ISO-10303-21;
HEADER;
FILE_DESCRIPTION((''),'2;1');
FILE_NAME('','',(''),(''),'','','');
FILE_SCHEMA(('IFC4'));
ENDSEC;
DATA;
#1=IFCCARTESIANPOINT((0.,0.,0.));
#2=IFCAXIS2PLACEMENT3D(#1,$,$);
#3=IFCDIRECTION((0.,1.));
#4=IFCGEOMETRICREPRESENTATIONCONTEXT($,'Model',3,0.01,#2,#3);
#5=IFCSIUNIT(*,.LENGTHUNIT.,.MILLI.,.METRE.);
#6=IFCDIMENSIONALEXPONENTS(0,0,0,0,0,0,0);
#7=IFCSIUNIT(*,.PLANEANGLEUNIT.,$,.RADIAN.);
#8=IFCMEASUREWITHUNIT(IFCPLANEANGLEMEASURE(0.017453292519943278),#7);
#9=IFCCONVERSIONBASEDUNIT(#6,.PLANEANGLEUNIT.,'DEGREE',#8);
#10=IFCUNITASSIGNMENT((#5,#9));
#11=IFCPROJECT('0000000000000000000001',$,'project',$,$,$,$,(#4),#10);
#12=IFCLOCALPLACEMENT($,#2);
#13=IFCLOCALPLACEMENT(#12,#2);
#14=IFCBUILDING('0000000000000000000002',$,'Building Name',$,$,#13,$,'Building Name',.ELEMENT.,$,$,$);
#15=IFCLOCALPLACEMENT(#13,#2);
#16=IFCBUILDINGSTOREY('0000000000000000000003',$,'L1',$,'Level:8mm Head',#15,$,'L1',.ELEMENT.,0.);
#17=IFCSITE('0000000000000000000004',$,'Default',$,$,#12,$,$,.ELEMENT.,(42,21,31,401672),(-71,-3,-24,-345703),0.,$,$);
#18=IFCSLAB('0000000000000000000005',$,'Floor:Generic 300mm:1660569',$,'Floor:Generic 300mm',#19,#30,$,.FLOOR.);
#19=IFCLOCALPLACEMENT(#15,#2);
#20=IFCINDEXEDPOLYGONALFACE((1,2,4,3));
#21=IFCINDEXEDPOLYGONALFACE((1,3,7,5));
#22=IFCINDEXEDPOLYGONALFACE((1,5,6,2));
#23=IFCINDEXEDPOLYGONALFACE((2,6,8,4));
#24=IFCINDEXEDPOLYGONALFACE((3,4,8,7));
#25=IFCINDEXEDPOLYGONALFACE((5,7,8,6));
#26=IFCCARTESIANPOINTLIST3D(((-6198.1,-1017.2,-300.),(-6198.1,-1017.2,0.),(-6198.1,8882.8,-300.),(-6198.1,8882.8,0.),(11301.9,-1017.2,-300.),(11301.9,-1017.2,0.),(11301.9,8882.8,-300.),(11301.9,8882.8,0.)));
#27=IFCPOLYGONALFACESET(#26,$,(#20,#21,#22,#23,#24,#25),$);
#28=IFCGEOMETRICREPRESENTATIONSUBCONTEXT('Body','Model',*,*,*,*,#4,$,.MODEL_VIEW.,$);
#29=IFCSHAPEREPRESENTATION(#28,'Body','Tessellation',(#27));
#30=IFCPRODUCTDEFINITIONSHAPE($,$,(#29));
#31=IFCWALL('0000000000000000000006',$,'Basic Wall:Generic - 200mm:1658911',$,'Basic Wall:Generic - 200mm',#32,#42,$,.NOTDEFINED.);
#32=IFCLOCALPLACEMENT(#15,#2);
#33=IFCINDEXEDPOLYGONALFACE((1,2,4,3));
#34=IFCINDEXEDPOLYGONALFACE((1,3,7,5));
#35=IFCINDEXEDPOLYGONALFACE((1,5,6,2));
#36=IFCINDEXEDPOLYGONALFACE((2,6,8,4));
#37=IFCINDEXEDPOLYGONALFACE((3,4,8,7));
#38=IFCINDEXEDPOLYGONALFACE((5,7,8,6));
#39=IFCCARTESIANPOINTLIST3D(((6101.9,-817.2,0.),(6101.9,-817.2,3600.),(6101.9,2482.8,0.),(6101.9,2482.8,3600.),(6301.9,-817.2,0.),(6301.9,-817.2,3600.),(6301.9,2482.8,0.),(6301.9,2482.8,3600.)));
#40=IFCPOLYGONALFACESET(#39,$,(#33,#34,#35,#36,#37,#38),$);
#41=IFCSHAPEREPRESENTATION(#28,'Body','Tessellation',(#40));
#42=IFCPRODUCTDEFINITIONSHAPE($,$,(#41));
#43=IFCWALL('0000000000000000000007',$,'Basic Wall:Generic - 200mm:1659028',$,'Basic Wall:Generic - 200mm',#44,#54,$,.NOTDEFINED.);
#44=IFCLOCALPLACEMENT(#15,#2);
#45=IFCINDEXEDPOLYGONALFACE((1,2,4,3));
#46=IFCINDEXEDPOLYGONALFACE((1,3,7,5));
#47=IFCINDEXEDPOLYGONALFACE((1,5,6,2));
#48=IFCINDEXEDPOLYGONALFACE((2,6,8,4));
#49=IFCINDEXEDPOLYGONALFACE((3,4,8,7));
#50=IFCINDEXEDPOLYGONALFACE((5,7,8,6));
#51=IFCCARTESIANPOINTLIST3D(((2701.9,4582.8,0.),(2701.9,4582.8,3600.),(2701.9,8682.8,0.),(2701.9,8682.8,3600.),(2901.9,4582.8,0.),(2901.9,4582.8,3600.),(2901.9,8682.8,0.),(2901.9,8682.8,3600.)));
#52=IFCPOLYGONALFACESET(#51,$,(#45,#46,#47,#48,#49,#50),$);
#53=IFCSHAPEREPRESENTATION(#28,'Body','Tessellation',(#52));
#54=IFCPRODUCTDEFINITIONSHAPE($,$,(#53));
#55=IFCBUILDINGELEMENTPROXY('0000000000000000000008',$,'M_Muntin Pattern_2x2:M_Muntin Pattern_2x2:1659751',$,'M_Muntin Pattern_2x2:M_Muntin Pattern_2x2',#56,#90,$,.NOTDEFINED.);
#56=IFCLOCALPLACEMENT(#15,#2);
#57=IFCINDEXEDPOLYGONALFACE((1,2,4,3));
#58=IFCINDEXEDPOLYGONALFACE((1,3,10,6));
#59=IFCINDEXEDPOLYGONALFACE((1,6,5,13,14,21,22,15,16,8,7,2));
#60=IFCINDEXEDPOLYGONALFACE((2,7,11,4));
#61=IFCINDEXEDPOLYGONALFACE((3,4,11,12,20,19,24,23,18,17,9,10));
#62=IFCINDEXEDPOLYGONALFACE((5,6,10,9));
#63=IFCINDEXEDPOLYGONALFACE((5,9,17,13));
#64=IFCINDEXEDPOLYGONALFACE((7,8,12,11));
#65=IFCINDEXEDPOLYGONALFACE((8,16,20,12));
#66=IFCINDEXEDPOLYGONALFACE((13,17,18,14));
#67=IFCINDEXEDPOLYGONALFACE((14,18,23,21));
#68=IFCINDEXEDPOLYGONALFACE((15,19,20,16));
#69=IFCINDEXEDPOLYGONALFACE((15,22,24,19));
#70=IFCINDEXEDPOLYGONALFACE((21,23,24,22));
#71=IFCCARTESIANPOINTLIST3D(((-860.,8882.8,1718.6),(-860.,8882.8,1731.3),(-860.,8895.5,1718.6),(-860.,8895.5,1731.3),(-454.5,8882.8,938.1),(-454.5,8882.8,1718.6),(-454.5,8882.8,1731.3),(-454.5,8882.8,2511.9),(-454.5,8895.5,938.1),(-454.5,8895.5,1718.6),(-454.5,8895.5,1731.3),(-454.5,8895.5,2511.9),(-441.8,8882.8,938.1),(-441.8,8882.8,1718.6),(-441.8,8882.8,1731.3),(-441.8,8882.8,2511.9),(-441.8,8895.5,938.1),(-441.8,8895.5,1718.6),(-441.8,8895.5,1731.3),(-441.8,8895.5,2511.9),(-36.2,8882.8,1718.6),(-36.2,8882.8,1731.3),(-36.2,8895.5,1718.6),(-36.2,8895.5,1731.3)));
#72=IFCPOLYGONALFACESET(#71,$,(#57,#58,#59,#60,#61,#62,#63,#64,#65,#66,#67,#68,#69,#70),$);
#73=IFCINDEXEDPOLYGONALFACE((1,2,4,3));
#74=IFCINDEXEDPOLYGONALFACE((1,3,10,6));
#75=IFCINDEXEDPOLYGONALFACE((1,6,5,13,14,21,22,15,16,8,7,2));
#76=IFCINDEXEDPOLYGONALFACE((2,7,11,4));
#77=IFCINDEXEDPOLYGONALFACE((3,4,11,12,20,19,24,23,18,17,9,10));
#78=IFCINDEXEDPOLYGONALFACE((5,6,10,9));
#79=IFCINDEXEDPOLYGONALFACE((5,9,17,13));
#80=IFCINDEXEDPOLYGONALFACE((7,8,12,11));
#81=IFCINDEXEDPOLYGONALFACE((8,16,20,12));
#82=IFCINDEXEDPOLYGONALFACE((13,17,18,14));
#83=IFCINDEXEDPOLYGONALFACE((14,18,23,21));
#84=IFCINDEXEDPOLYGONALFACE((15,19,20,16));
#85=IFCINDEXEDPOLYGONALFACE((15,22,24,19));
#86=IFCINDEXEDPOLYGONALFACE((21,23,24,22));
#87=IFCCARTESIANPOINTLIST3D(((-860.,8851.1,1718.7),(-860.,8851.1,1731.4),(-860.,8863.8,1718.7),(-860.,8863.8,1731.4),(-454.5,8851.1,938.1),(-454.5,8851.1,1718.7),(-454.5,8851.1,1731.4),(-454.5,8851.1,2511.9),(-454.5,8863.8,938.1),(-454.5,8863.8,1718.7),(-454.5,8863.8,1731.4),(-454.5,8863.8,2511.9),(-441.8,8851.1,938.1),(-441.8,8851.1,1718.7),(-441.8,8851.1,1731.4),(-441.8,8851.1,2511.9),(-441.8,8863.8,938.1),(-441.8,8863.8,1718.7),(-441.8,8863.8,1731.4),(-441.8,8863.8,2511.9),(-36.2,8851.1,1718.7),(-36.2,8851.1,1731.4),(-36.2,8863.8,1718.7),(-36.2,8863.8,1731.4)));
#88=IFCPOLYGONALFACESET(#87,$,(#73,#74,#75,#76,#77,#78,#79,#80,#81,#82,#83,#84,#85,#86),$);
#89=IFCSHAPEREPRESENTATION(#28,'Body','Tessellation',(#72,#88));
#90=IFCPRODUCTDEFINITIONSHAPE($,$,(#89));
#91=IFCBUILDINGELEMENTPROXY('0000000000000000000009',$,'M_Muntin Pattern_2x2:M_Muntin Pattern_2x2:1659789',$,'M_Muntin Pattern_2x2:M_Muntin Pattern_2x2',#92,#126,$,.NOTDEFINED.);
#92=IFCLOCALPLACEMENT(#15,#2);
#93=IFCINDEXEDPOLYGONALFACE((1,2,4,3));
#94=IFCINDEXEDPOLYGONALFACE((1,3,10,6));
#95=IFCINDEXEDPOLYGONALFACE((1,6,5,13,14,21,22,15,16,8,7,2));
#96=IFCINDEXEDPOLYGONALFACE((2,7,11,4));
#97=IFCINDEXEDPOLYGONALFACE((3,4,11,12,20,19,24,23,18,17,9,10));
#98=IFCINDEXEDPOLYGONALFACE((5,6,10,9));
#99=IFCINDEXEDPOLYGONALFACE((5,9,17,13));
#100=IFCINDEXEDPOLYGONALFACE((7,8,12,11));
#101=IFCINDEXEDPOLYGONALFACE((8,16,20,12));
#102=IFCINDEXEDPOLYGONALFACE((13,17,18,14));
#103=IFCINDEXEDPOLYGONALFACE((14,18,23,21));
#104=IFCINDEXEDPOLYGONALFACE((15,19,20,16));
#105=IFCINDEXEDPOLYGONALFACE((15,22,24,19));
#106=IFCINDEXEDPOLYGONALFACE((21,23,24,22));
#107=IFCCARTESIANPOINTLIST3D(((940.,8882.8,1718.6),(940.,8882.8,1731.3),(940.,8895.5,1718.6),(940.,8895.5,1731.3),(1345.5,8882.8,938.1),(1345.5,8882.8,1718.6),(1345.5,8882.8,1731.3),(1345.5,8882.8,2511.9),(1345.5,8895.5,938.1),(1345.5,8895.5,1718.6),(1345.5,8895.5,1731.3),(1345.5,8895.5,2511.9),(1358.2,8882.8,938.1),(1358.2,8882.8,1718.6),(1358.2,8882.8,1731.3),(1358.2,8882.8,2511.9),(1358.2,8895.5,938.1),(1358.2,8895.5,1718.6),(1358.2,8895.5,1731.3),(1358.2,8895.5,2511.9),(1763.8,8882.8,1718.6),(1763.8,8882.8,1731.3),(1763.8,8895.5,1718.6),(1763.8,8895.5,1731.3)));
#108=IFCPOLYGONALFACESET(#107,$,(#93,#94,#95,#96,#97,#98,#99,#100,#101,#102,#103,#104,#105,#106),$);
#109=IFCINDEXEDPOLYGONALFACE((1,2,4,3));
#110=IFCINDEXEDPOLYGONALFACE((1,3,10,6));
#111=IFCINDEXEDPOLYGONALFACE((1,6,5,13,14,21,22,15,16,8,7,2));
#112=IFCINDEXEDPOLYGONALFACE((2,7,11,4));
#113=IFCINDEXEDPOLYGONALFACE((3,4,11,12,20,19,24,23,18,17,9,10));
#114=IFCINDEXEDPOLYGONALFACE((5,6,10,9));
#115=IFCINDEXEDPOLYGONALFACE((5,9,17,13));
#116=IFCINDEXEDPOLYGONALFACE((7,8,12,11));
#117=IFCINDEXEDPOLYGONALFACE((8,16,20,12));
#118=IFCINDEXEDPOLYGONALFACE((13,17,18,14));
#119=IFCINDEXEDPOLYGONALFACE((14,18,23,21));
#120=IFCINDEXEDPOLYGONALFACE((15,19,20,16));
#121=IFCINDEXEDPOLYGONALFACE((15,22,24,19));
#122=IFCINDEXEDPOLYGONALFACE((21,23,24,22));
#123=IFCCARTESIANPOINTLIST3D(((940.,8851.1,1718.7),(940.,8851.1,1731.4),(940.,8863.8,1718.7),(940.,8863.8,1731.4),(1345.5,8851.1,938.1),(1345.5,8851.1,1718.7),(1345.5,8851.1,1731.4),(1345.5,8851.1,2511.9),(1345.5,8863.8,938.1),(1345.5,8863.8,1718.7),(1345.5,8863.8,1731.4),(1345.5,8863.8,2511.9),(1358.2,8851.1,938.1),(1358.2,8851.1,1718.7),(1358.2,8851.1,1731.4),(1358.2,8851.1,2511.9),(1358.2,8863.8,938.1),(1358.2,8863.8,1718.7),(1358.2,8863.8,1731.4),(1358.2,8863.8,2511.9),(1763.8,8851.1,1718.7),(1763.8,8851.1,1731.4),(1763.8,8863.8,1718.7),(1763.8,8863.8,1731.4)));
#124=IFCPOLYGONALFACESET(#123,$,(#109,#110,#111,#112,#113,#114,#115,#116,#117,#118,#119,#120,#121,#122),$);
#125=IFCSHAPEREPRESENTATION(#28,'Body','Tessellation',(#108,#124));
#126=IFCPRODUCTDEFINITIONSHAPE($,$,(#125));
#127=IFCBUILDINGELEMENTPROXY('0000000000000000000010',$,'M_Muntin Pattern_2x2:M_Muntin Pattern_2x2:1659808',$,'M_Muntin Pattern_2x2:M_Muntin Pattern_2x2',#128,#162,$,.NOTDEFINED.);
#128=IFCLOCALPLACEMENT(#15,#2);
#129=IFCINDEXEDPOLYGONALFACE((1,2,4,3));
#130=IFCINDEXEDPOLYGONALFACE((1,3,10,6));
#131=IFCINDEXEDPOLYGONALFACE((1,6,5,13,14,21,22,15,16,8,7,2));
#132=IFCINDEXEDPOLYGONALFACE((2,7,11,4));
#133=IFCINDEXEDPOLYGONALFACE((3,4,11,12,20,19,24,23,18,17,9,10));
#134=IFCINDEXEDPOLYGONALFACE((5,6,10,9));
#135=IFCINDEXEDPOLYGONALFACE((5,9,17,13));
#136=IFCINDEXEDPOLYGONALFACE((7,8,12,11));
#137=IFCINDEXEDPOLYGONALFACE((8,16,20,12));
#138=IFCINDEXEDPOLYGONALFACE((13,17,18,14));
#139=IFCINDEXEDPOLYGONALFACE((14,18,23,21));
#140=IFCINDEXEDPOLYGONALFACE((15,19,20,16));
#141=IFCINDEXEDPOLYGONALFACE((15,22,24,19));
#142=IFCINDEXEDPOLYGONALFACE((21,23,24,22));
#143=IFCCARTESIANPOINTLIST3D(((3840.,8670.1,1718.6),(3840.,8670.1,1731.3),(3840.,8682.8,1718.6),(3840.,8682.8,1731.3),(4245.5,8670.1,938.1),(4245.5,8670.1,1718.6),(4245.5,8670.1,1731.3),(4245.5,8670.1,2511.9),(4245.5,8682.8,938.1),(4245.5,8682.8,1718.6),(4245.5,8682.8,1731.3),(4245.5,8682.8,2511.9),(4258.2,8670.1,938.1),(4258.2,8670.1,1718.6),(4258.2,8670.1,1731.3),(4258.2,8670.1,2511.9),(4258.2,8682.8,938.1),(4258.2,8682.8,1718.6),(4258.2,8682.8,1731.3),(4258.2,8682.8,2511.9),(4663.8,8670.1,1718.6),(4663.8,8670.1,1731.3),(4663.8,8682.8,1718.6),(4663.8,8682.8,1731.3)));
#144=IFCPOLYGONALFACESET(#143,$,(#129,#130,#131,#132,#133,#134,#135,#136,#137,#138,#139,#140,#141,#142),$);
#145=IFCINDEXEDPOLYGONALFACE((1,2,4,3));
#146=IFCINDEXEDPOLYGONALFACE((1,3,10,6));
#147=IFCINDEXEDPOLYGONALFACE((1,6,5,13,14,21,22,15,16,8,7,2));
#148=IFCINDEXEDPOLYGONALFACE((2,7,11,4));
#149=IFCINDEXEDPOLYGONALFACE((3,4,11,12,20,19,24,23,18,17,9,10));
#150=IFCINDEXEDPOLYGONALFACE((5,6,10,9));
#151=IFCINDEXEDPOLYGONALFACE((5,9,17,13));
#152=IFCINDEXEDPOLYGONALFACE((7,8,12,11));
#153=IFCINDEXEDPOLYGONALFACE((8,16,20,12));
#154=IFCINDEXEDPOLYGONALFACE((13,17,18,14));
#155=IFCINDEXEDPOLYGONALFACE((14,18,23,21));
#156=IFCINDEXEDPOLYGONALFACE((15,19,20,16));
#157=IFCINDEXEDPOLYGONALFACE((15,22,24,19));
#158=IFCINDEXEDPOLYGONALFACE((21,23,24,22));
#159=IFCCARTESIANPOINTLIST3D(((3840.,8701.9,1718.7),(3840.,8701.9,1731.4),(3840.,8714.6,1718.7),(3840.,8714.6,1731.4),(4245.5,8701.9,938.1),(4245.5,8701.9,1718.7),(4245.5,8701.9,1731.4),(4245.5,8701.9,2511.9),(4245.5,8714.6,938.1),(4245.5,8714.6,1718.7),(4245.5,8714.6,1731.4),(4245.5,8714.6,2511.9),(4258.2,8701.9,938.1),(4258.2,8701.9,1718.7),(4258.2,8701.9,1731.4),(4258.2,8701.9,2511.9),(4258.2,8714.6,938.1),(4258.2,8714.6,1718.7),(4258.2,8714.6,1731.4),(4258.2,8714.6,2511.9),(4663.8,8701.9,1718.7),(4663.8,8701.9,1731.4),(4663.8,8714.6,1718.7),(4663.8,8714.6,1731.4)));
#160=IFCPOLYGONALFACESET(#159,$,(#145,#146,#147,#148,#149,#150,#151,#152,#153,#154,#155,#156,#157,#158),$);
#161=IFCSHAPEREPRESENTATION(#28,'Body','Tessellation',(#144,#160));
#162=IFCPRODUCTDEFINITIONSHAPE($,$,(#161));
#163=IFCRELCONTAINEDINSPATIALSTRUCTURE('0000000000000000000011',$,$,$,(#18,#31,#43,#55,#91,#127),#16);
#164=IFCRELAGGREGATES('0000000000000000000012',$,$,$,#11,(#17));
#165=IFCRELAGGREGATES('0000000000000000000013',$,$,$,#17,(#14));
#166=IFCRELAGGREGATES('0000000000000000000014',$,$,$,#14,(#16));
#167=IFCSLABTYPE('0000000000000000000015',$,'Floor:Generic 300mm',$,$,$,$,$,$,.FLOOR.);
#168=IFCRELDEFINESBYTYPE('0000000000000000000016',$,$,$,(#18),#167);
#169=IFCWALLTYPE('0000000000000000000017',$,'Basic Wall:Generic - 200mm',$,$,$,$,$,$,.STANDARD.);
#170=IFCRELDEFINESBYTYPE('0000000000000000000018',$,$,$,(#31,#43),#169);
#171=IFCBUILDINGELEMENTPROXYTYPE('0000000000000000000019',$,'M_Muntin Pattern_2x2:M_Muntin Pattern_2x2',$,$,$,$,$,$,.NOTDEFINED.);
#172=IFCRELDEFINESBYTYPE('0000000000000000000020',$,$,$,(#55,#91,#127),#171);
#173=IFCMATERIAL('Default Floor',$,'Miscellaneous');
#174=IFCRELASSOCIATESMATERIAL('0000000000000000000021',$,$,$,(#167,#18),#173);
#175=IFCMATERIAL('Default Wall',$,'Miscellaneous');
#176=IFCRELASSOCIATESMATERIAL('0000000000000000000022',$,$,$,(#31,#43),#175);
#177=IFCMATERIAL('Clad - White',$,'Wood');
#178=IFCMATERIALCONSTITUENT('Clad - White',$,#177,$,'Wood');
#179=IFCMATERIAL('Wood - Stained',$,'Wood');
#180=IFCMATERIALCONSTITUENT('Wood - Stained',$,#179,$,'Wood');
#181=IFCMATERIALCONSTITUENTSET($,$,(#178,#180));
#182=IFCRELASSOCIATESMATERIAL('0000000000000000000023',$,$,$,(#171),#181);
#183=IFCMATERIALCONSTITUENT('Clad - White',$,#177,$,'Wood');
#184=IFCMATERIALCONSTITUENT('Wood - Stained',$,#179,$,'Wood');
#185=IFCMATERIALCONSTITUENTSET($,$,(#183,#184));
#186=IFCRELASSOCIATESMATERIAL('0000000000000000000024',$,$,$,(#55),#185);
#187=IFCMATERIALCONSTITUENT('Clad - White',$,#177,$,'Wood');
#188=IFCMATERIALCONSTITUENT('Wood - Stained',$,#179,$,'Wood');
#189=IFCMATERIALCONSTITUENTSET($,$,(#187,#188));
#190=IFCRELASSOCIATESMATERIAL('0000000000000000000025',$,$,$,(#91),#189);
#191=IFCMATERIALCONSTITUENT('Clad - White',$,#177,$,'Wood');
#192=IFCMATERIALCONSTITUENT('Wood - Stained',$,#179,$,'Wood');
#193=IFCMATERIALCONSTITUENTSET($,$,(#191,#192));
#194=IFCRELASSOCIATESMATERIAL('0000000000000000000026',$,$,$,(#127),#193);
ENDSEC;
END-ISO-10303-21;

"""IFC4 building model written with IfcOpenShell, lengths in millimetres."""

from ifc_helpers import new_model, entity, si_unit, converted_unit, direction, frame, origin, place, context, subcontext, project, spatial, indexed_curve, outline, extrude, source, transform, mapped, material, constituent, constituent_set, type_object, type_shapes, element, save


model = new_model("IFC4")

# Units and contexts
model_context = context("Model", 3, precision=0.01, world=origin(), true_north=direction((0.0, 1.0)))
body_context = subcontext(model_context, "Body", "Model", "MODEL_VIEW")
ifc_project = project(units=[si_unit("LENGTHUNIT", "METRE", prefix="MILLI"), converted_unit("PLANEANGLEUNIT", "DEGREE", entity("IfcPlaneAngleMeasure", 0.017453292519943278), si_unit("PLANEANGLEUNIT", "RADIAN"), dimensions=[0, 0, 0, 0, 0, 0, 0])], contexts=[model_context])

# Site, building, storey
site_placement = place(None, origin())
site = spatial("IfcSite", under=ifc_project, at=site_placement, Name="Default", CompositionType="ELEMENT", RefLatitude=(42, 21, 31, 401672), RefLongitude=(-71, -3, -24, -345703), RefElevation=0.0)
building_placement = place(site_placement, origin())
building = spatial("IfcBuilding", under=site, at=building_placement, Name="Building Name", LongName="Building Name", CompositionType="ELEMENT")
storey_placement = place(building_placement, origin())
storey = spatial("IfcBuildingStorey", under=building, at=storey_placement, Name="L1", ObjectType="Level:8mm Head", LongName="L1", CompositionType="ELEMENT", Elevation=0.0)

# Slab
ifc_material_1 = material(Name="Default Floor", Category="Miscellaneous")
slab_type = type_object("IfcSlabType", Name="Floor:Generic 300mm", PredefinedType="FLOOR", material=ifc_material_1)
slab_placement = place(storey_placement, origin())
element("IfcSlab", 1, at=slab_placement, inside=storey, type_object=slab_type, material=ifc_material_1, Name="Floor:Generic 300mm:1660569", ObjectType="Floor:Generic 300mm", PredefinedType="FLOOR", context=body_context, shape_type="SweptSolid", body=[
    extrude(outline(indexed_curve([(-4950.0, -8750.0), (4950.0, -8750.0), (4950.0, 8750.0), (-4950.0, 8750.0), (-4950.0, -8750.0)], self_intersect=False)), frame((2551.9, 3932.8, 0.0), z_axis=(0.0, 0.0, -1.0), x_axis=(0.0, 1.0, 0.0)), (0.0, 0.0, 1.0), 300.0),
])

# Walls
ifc_material_2 = material(Name="Default Wall", Category="Miscellaneous")
wall_type = type_object("IfcWallType", Name="Basic Wall:Generic - 200mm", PredefinedType="STANDARD")
wall_1_placement = place(storey_placement, frame((6201.9, 2482.8, 0.0), z_axis=(0.0, 0.0, 1.0), x_axis=(0.0, -1.0, 0.0)))
element("IfcWall", 2, at=wall_1_placement, inside=storey, type_object=wall_type, material=ifc_material_2, Name="Basic Wall:Generic - 200mm:1658911", ObjectType="Basic Wall:Generic - 200mm", PredefinedType="NOTDEFINED", context=body_context, shape_type="SweptSolid", body=[
    extrude(outline(indexed_curve([(3300.0, 100.0), (0.0, 100.0), (0.0, -100.0), (3300.0, -100.0), (3300.0, 100.0)], self_intersect=False)), origin(), (0.0, 0.0, 1.0), 3600.0),
])
wall_2_placement = place(storey_placement, frame((2801.9, 4582.8, 0.0), z_axis=(0.0, 0.0, 1.0), x_axis=(0.0, 1.0, 0.0)))
element("IfcWall", 3, at=wall_2_placement, inside=storey, type_object=wall_type, material=ifc_material_2, Name="Basic Wall:Generic - 200mm:1659028", ObjectType="Basic Wall:Generic - 200mm", PredefinedType="NOTDEFINED", context=body_context, shape_type="SweptSolid", body=[
    extrude(outline(indexed_curve([(4100.0, 100.0), (0.0, 100.0), (0.0, -100.0), (4100.0, -100.0), (4100.0, 100.0)], self_intersect=False)), origin(), (0.0, 0.0, 1.0), 3600.0),
])

# Building element proxies
ifc_material_3 = material(Name="Clad - White", Category="Wood")
ifc_constituent_1 = constituent(ifc_material_3, Name="Clad - White", Category="Wood")
ifc_material_4 = material(Name="Wood - Stained", Category="Wood")
ifc_constituent_2 = constituent(ifc_material_4, Name="Wood - Stained", Category="Wood")
ifc_constituent_set_1 = constituent_set(constituents=[ifc_constituent_1, ifc_constituent_2])
ifc_constituent_3 = constituent(ifc_material_3, Name="Clad - White", Category="Wood")
ifc_constituent_4 = constituent(ifc_material_4, Name="Wood - Stained", Category="Wood")
ifc_constituent_set_2 = constituent_set(constituents=[ifc_constituent_3, ifc_constituent_4])
building_element_proxy_type_1 = type_object("IfcBuildingElementProxyType", Name="M_Muntin Pattern_2x2:M_Muntin Pattern_2x2", PredefinedType="NOTDEFINED", material=ifc_constituent_set_2)
shared_shape_1 = source(origin(), body_context, "Body", "SweptSolid", [
    extrude(outline(indexed_curve([(6.4, -6.4), (786.9, -6.4), (786.9, 6.3), (6.4, 6.3), (6.4, 411.9), (-6.3, 411.9), (-6.3, 6.3), (-786.9, 6.3), (-786.9, -6.4), (-6.3, -6.4), (-6.3, -411.9), (6.4, -411.9), (6.4, -6.4)], self_intersect=False)), frame((0.0, -22.2, 786.9), z_axis=(0.0, 1.0, 0.0), x_axis=(0.0, 0.0, 1.0)), (0.0, 0.0, 1.0), 12.7),
    extrude(outline(indexed_curve([(6.4, -6.4), (786.9, -6.4), (786.9, 6.3), (6.4, 6.3), (6.4, 411.9), (-6.3, 411.9), (-6.3, 6.3), (-786.9, 6.3), (-786.9, -6.4), (-6.3, -6.4), (-6.3, -411.9), (6.4, -411.9), (6.4, -6.4)], self_intersect=False)), frame((0.0, 9.5, 786.9), z_axis=(0.0, 1.0, 0.0), x_axis=(0.0, 0.0, 1.0)), (0.0, 0.0, 1.0), 12.7),
])
type_shapes(building_element_proxy_type_1, [shared_shape_1])
proxy_1_placement = place(storey_placement, frame((-448.1, 8873.3, 938.1), z_axis=(0.0, 0.0, 1.0), x_axis=(-1.0, 0.0, 0.0)))
element("IfcBuildingElementProxy", 4, at=proxy_1_placement, inside=storey, type_object=building_element_proxy_type_1, material=ifc_constituent_set_1, Name="M_Muntin Pattern_2x2:M_Muntin Pattern_2x2:1659751", ObjectType="M_Muntin Pattern_2x2:M_Muntin Pattern_2x2", PredefinedType="NOTDEFINED", context=body_context, shape_type="MappedRepresentation", body=[
    mapped(shared_shape_1, transform((0.0, 0.0, 0.0), scale=1.0)),
])
ifc_constituent_5 = constituent(ifc_material_3, Name="Clad - White", Category="Wood")
ifc_constituent_6 = constituent(ifc_material_4, Name="Wood - Stained", Category="Wood")
ifc_constituent_set_3 = constituent_set(constituents=[ifc_constituent_5, ifc_constituent_6])
proxy_2_placement = place(storey_placement, frame((1351.9, 8873.3, 938.1), z_axis=(0.0, 0.0, 1.0), x_axis=(-1.0, 0.0, 0.0)))
element("IfcBuildingElementProxy", 5, at=proxy_2_placement, inside=storey, type_object=building_element_proxy_type_1, material=ifc_constituent_set_3, Name="M_Muntin Pattern_2x2:M_Muntin Pattern_2x2:1659789", ObjectType="M_Muntin Pattern_2x2:M_Muntin Pattern_2x2", PredefinedType="NOTDEFINED", context=body_context, shape_type="MappedRepresentation", body=[
    mapped(shared_shape_1, transform((0.0, 0.0, 0.0), scale=1.0)),
])
ifc_constituent_7 = constituent(ifc_material_3, Name="Clad - White", Category="Wood")
ifc_constituent_8 = constituent(ifc_material_4, Name="Wood - Stained", Category="Wood")
ifc_constituent_set_4 = constituent_set(constituents=[ifc_constituent_7, ifc_constituent_8])
proxy_3_placement = place(storey_placement, frame((4251.9, 8692.3, 938.1)))
element("IfcBuildingElementProxy", 6, at=proxy_3_placement, inside=storey, type_object=building_element_proxy_type_1, material=ifc_constituent_set_4, Name="M_Muntin Pattern_2x2:M_Muntin Pattern_2x2:1659808", ObjectType="M_Muntin Pattern_2x2:M_Muntin Pattern_2x2", PredefinedType="NOTDEFINED", context=body_context, shape_type="MappedRepresentation", body=[
    mapped(shared_shape_1, transform((0.0, 0.0, 0.0), scale=1.0)),
])

save(model, "model.ifc")
